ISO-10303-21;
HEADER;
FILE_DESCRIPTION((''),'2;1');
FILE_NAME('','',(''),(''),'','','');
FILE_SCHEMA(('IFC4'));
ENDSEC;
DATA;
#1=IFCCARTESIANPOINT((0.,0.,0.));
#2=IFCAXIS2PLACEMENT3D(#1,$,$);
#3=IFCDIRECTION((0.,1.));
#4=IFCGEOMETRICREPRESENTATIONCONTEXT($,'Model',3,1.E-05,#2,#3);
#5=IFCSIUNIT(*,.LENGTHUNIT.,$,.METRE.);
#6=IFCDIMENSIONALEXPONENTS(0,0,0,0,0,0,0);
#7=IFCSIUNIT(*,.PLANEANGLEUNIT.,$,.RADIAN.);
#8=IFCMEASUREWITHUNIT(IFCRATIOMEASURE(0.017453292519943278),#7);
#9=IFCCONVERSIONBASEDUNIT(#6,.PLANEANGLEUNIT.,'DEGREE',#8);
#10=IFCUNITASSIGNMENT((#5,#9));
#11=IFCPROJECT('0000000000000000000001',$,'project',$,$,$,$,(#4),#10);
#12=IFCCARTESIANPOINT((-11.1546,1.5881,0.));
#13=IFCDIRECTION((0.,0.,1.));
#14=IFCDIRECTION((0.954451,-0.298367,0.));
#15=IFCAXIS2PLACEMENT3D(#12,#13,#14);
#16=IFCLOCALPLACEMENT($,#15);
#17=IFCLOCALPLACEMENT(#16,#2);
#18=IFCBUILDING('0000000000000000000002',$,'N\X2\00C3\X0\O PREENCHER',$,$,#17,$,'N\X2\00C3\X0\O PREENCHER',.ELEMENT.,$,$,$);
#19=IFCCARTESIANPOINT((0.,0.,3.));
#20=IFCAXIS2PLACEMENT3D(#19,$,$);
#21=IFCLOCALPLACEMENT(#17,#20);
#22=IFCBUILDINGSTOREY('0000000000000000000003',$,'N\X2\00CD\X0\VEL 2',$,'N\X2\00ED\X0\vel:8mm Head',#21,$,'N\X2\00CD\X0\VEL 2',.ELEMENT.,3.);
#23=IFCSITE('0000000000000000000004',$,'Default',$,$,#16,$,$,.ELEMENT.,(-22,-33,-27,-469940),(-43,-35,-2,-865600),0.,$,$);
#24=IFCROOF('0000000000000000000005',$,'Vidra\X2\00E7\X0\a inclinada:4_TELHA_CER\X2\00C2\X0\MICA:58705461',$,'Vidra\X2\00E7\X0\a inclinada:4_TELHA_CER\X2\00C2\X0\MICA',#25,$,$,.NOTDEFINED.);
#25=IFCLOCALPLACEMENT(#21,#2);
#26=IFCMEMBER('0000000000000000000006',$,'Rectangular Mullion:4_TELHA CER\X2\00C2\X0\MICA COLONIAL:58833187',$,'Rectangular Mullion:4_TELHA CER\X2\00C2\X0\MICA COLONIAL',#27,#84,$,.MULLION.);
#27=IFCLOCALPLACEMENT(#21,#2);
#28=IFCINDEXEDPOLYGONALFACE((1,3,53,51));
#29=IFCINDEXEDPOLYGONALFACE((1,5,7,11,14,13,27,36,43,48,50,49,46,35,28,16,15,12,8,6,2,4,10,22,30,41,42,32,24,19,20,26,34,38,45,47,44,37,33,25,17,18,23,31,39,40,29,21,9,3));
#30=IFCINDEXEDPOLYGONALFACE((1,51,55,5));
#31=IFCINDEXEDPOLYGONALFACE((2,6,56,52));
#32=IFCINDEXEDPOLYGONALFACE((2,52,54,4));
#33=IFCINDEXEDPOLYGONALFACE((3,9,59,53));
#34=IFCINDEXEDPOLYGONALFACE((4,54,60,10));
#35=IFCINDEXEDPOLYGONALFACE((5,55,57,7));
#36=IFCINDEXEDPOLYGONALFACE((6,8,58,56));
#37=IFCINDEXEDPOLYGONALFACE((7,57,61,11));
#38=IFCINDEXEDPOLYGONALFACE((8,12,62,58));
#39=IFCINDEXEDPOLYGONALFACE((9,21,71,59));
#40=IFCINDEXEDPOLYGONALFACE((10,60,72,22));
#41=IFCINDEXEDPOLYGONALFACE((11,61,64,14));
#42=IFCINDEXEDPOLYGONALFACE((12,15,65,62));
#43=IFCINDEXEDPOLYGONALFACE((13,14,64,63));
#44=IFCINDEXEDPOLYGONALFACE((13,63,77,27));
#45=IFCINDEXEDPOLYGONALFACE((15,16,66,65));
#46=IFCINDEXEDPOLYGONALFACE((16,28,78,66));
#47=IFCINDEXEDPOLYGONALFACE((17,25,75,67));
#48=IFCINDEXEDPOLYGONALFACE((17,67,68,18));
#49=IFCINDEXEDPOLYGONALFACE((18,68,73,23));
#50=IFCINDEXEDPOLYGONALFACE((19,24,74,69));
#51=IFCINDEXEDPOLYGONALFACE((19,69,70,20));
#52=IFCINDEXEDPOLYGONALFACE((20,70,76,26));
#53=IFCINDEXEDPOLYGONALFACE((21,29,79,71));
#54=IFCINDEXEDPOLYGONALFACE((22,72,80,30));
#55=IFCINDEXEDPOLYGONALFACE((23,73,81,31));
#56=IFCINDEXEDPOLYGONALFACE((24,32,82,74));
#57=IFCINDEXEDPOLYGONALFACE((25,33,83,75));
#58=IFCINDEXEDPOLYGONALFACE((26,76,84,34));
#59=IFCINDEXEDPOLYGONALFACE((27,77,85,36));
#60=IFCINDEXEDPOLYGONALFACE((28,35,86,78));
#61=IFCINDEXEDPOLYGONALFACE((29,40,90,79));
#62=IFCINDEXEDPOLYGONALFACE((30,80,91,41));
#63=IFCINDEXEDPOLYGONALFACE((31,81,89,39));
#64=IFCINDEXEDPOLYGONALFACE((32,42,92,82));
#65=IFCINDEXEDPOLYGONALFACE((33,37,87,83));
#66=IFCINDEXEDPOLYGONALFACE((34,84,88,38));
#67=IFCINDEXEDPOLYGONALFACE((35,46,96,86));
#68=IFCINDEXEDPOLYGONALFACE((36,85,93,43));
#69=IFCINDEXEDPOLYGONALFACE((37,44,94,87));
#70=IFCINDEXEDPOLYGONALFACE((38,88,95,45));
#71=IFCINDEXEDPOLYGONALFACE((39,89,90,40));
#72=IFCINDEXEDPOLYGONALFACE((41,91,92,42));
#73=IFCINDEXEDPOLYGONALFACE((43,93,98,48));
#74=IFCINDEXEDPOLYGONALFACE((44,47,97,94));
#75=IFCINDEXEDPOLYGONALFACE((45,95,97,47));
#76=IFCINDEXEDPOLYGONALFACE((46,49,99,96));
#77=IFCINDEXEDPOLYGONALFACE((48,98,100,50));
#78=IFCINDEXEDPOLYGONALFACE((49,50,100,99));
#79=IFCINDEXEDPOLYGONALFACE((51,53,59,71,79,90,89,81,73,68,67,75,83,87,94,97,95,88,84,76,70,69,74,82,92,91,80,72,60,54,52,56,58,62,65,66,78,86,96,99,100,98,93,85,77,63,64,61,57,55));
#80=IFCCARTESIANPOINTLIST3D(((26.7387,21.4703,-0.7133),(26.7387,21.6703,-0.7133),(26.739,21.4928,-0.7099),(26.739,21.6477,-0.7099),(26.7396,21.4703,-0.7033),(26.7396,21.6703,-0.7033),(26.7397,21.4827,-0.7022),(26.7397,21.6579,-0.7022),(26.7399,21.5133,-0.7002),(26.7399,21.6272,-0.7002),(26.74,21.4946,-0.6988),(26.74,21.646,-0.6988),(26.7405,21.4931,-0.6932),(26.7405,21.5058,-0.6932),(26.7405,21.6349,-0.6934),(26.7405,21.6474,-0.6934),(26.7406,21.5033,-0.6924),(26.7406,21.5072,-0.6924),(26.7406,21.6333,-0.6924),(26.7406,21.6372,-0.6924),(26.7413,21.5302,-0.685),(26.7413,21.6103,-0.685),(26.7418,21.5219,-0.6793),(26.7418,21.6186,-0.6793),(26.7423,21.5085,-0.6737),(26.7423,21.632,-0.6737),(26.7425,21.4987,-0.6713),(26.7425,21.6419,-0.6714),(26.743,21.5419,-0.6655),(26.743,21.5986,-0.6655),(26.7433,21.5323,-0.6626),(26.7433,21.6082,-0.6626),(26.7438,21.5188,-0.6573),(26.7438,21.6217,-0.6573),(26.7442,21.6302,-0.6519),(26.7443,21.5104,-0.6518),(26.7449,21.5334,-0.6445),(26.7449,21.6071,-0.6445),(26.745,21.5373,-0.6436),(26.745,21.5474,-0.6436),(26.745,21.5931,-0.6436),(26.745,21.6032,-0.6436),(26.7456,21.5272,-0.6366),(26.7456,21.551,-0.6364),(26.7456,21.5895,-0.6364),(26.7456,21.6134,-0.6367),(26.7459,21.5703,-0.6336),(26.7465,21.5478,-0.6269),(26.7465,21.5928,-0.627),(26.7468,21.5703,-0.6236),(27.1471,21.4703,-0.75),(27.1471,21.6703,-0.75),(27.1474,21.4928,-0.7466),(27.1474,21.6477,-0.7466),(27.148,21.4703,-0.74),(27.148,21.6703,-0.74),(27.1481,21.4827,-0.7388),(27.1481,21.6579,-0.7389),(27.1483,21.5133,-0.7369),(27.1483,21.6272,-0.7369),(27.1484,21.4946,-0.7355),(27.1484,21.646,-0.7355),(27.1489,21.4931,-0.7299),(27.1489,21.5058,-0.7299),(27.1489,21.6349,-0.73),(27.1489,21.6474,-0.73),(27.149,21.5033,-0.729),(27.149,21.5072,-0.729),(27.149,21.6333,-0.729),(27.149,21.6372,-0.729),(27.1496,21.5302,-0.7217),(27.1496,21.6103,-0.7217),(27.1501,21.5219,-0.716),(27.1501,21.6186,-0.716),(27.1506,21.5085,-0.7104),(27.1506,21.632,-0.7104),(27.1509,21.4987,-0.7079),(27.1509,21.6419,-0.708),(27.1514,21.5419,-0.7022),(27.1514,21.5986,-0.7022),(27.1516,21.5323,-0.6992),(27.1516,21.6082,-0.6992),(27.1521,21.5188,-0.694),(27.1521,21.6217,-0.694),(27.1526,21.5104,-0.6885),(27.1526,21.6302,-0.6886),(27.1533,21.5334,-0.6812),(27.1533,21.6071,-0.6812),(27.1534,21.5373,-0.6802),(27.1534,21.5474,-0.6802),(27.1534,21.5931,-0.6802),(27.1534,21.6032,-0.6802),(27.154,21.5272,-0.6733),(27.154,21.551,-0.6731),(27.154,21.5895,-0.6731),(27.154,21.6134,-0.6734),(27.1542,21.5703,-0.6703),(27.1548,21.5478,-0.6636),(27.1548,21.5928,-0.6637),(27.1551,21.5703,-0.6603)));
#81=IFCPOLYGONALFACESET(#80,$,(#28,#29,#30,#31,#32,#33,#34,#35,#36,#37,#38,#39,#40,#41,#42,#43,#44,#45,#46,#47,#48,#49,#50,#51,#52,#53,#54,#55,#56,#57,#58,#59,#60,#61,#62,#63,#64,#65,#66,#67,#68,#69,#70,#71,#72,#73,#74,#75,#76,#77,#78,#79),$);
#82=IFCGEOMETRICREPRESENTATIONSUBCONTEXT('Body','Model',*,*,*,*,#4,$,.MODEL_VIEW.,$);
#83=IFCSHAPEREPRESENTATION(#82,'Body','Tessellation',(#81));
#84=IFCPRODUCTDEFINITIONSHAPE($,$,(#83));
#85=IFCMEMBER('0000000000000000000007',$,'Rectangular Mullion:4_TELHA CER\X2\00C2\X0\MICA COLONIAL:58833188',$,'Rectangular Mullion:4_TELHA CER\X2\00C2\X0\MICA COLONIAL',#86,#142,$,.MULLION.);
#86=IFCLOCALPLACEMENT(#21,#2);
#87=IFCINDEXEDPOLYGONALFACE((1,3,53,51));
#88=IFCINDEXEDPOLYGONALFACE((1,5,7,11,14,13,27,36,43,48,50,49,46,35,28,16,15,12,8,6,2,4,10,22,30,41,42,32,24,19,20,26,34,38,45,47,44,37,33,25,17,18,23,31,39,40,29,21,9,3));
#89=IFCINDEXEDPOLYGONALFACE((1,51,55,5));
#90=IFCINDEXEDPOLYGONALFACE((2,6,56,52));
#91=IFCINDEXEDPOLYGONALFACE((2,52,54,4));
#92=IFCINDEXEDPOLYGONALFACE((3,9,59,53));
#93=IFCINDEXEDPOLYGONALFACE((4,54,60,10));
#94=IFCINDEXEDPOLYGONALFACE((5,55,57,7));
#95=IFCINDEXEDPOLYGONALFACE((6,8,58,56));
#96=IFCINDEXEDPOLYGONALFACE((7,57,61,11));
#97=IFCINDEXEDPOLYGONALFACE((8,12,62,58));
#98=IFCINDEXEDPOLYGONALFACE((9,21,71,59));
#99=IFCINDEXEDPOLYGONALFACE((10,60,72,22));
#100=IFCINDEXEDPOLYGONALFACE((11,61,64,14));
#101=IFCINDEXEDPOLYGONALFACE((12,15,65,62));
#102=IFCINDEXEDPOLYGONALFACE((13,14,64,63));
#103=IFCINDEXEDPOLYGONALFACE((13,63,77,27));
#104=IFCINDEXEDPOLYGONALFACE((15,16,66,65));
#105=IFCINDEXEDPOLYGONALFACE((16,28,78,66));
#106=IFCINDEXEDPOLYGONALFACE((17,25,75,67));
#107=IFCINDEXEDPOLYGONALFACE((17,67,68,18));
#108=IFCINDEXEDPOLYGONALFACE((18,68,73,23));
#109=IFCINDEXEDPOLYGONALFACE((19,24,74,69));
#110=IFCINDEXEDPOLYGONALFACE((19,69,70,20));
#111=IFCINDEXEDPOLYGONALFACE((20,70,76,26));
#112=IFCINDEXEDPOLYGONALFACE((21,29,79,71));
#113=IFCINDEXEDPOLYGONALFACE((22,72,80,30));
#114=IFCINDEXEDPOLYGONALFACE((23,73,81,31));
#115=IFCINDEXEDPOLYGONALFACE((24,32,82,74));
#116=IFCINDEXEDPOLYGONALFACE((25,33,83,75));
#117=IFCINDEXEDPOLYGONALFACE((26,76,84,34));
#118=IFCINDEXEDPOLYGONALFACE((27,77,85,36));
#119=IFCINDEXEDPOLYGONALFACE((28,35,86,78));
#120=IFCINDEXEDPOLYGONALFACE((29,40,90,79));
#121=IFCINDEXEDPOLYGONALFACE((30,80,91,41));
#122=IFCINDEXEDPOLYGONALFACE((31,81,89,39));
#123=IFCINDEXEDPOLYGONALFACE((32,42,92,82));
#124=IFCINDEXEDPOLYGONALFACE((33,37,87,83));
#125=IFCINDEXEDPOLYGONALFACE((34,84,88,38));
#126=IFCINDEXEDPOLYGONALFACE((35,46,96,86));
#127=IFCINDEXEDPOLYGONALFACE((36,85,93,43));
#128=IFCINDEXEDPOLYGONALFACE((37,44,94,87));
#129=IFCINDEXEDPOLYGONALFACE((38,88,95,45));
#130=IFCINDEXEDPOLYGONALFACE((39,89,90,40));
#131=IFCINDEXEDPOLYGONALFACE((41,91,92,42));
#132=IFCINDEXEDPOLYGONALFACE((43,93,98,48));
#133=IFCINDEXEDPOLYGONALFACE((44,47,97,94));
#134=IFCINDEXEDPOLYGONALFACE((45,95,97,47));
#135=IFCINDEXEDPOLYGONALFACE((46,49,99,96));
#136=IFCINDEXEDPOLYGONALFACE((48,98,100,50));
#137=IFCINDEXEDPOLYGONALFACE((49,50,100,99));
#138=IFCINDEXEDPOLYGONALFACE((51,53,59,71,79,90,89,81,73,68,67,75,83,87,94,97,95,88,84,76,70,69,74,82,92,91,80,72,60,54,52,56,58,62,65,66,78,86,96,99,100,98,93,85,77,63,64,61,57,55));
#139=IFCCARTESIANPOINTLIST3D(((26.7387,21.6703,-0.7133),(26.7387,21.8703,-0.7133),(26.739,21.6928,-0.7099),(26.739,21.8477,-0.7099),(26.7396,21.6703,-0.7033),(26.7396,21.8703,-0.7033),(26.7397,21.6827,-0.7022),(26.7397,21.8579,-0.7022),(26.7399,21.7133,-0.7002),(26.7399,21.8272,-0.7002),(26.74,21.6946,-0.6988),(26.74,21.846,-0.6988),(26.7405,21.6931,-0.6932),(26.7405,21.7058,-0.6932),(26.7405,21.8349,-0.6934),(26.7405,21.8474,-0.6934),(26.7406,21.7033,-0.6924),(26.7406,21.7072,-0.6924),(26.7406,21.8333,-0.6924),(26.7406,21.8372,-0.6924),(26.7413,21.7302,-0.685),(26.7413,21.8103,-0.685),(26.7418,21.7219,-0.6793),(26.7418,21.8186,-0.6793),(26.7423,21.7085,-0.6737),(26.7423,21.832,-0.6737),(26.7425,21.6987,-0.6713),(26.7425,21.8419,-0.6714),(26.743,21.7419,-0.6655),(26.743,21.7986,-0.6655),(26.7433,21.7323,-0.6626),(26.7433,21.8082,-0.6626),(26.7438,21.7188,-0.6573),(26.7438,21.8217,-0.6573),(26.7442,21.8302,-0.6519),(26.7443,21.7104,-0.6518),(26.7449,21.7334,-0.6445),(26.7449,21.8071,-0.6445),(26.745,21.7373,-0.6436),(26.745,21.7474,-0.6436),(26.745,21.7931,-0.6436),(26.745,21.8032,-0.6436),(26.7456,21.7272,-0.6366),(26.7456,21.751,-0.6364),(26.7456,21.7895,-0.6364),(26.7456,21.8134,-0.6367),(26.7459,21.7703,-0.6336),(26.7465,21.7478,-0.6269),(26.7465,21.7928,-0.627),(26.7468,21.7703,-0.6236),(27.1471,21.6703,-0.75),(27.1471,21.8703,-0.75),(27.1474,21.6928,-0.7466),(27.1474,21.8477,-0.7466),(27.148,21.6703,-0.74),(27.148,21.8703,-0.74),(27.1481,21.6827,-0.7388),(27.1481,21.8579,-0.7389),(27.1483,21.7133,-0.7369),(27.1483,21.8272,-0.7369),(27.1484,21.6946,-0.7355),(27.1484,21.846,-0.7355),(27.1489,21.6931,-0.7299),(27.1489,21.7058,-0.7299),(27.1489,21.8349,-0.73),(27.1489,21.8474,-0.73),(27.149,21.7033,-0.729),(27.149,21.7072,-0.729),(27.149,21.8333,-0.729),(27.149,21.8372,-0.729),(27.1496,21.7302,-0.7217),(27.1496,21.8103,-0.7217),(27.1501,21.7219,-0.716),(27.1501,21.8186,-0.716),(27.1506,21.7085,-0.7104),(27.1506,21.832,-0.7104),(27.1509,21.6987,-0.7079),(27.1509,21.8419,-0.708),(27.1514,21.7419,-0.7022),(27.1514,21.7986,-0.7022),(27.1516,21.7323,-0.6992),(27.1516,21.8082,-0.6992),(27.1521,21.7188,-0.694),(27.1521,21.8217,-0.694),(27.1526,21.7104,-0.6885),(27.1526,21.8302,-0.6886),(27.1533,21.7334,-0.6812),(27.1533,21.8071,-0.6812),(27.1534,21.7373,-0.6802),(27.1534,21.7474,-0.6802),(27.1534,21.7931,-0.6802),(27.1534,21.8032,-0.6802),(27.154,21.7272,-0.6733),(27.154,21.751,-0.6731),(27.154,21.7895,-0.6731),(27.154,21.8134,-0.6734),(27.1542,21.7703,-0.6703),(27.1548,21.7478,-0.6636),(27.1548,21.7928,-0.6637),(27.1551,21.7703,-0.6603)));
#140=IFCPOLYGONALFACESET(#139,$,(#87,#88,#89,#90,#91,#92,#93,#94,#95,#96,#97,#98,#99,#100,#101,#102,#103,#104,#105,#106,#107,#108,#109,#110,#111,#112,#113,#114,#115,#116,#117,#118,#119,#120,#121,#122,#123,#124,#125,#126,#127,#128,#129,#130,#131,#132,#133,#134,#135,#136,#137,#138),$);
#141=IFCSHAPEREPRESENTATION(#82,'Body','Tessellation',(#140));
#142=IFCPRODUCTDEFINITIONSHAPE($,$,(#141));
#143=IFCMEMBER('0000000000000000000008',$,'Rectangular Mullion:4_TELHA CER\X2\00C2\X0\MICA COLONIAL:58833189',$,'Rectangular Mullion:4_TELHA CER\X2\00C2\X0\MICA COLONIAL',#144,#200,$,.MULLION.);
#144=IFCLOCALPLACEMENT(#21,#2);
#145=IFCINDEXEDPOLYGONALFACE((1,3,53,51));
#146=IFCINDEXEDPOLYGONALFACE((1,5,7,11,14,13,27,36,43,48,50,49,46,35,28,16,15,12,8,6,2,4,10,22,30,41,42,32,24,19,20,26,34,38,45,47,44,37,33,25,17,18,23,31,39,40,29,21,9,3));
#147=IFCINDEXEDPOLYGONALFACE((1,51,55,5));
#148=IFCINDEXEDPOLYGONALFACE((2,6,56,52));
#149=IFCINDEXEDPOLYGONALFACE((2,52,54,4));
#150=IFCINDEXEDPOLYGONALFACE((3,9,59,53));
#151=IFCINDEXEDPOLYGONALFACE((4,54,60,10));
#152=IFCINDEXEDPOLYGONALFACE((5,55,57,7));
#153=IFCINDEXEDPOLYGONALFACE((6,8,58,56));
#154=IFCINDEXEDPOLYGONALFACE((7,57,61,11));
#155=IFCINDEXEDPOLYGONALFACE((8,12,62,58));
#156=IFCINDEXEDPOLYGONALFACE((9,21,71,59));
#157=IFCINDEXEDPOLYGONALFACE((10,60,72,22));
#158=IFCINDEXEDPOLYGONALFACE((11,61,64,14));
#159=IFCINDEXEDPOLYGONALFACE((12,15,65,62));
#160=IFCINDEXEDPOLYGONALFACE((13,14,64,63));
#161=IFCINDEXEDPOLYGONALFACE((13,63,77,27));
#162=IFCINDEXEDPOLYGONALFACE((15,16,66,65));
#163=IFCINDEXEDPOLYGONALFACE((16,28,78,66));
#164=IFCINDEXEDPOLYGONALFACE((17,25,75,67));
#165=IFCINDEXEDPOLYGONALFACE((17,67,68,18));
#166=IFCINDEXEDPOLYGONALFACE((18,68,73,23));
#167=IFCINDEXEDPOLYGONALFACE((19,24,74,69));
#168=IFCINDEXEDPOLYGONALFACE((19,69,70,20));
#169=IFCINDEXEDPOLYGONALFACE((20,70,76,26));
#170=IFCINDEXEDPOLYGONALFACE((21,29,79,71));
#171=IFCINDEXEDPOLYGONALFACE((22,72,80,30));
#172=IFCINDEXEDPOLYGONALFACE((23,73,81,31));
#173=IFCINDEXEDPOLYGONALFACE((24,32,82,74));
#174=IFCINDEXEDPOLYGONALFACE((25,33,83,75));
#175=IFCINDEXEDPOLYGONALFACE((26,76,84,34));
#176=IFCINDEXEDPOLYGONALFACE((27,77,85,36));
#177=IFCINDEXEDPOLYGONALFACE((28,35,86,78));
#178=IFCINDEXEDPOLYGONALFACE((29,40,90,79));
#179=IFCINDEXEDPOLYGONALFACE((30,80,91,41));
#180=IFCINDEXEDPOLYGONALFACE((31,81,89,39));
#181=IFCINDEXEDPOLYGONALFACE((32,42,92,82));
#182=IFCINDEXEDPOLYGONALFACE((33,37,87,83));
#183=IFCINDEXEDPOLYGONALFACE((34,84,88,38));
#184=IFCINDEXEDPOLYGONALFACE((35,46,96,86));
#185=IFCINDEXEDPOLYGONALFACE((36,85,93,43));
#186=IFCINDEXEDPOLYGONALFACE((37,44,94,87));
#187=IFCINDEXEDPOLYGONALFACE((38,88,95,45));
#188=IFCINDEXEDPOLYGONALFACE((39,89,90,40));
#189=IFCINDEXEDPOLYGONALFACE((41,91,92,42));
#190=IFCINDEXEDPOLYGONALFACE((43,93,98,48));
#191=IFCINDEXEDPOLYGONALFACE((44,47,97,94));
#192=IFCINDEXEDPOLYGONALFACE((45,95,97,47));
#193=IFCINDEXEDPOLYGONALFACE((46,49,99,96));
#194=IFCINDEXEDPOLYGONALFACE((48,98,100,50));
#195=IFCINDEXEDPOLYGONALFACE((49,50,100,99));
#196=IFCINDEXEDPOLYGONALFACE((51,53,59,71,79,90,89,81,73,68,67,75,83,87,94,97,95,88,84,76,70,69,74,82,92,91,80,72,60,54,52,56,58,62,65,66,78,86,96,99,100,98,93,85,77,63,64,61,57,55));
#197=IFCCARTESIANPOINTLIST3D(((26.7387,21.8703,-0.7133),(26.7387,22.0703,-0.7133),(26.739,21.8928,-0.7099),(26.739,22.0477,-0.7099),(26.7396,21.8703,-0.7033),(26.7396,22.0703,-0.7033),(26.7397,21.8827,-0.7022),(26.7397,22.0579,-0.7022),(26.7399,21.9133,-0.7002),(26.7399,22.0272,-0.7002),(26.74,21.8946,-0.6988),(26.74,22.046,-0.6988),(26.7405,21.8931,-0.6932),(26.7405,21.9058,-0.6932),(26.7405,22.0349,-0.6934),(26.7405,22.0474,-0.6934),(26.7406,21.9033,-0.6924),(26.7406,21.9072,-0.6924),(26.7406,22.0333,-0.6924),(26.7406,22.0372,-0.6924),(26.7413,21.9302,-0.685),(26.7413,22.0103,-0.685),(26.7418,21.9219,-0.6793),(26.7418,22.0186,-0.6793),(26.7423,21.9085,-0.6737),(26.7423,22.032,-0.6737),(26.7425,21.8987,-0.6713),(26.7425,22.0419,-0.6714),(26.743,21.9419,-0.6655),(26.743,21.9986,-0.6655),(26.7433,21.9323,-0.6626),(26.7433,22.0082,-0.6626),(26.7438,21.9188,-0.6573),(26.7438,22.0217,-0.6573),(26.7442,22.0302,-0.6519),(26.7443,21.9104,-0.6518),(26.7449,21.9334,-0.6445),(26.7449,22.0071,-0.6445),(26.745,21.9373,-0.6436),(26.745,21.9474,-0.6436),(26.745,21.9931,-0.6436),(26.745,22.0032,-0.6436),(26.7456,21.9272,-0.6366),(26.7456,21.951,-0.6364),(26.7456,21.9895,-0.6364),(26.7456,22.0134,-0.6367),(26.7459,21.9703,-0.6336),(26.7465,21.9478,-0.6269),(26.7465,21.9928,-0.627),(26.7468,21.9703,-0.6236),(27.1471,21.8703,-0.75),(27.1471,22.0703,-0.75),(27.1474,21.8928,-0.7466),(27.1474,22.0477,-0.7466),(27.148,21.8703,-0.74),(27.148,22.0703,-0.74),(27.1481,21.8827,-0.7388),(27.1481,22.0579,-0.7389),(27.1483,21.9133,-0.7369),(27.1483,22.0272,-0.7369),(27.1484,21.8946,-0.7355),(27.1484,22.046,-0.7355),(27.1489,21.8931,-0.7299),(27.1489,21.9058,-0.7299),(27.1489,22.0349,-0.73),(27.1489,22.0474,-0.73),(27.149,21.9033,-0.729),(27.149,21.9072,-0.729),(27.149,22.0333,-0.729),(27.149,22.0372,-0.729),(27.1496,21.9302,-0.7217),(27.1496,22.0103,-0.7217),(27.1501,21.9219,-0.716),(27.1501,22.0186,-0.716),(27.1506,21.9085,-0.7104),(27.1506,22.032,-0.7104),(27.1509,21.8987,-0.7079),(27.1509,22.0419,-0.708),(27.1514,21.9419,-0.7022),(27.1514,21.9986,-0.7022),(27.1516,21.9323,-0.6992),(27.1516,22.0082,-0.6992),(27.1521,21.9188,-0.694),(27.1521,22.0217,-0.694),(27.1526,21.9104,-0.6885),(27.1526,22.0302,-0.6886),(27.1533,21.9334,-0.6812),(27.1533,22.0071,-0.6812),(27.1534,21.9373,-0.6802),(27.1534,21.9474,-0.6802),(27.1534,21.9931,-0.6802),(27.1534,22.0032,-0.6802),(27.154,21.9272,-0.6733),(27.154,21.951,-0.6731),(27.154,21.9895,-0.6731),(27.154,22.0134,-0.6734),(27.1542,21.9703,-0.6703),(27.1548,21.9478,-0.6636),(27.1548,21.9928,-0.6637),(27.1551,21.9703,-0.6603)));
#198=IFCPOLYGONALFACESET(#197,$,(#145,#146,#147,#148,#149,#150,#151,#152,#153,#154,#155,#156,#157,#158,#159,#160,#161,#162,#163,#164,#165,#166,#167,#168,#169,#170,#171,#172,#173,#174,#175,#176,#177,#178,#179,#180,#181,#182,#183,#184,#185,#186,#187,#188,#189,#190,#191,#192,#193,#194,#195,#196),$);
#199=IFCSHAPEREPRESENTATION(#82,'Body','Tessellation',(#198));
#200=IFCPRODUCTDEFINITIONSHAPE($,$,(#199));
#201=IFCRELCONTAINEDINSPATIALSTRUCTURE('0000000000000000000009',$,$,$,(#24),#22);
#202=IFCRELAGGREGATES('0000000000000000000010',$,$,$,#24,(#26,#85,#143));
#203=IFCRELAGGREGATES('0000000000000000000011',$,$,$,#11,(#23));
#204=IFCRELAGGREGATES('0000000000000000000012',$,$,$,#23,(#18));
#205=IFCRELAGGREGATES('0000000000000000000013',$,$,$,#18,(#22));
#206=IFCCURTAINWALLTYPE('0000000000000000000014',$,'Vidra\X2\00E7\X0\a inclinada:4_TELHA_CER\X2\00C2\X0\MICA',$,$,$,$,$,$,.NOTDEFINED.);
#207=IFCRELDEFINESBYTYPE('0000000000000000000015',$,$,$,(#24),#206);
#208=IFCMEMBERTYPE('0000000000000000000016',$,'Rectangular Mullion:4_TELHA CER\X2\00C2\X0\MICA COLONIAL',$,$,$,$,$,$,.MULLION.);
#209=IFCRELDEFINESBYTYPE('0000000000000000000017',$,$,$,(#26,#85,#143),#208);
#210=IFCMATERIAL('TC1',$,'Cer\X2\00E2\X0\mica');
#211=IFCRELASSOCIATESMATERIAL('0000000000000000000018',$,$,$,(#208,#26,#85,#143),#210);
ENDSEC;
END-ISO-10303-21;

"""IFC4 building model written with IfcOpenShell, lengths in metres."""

from ifc_helpers import new_model, entity, si_unit, converted_unit, direction, frame, origin, place, context, subcontext, project, spatial, line, arc, indexed_curve, outline, extrude, source, transform, mapped, material, type_object, type_shapes, element, aggregate, save


model = new_model("IFC4")

# Units and contexts
model_context = context("Model", 3, precision=1e-05, world=origin(), true_north=direction((0.0, 1.0)))
body_context = subcontext(model_context, "Body", "Model", "MODEL_VIEW")
ifc_project = project(units=[si_unit("LENGTHUNIT", "METRE"), converted_unit("PLANEANGLEUNIT", "DEGREE", entity("IfcRatioMeasure", 0.017453292519943278), si_unit("PLANEANGLEUNIT", "RADIAN"), dimensions=[0, 0, 0, 0, 0, 0, 0])], contexts=[model_context])

# Site, building, storey
site_placement = place(None, frame((-11.1546, 1.5881, 0.0), z_axis=(0.0, 0.0, 1.0), x_axis=(0.954451, -0.298367, 0.0)))
site = spatial("IfcSite", under=ifc_project, at=site_placement, Name="Default", CompositionType="ELEMENT", RefLatitude=(-22, -33, -27, -469940), RefLongitude=(-43, -35, -2, -865600), RefElevation=0.0)
building_placement = place(site_placement, origin())
building = spatial("IfcBuilding", under=site, at=building_placement, Name="NÃO PREENCHER", LongName="NÃO PREENCHER", CompositionType="ELEMENT")
storey_placement = place(building_placement, frame((0.0, 0.0, 3.0)))
storey = spatial("IfcBuildingStorey", under=building, at=storey_placement, Name="NÍVEL 2", ObjectType="Nível:8mm Head", LongName="NÍVEL 2", CompositionType="ELEMENT", Elevation=3.0)

# Roof, members
curtain_wall_type = type_object("IfcCurtainWallType", Name="Vidraça inclinada:4_TELHA_CERÂMICA", PredefinedType="NOTDEFINED")
roof_placement = place(storey_placement, frame((0.0, 0.0, -3.0)))
roof = element("IfcRoof", 1, at=roof_placement, inside=storey, type_object=curtain_wall_type, Name="Vidraça inclinada:4_TELHA_CERÂMICA:58705461", ObjectType="Vidraça inclinada:4_TELHA_CERÂMICA", PredefinedType="NOTDEFINED")
ifc_material = material(Name="TC1", Category="Cerâmica")
member_type_1 = type_object("IfcMemberType", Name="Rectangular Mullion:4_TELHA CERÂMICA COLONIAL", PredefinedType="MULLION", material=ifc_material)
shared_shape_1 = source(origin(), body_context, "Body", "SweptSolid", [
    extrude(outline(indexed_curve([(-0.029, -0.1), (-0.019, -0.1), (-0.0164, -0.0815), (-0.0089, -0.0645), (-0.0089, -0.0771), (0.061, 0.0), (-0.009, 0.0771), (-0.009, 0.0646), (-0.0165, 0.0816), (-0.019, 0.1), (-0.029, 0.1), (-0.0089, 0.0479), (0.041, 0.0229), (0.041, 0.0329), (0.0131, 0.0425), (-0.008, 0.0631), (-0.008, 0.067), (0.051, 0.0), (-0.008, -0.067), (-0.008, -0.0631), (0.0131, -0.0425), (0.041, -0.0329), (0.041, -0.0229), (-0.0089, -0.0479)], segments=[line(1, 2), arc(2, 3, 4), line(4, 5), arc(5, 6, 7), line(7, 8), arc(8, 9, 10), line(10, 11), arc(11, 12, 13), line(13, 14), arc(14, 15, 16), line(16, 17), arc(17, 18, 19), line(19, 20), arc(20, 21, 22), line(22, 23), arc(23, 24, 1)], self_intersect=False)), frame((0.0, -0.029, -0.41), z_axis=(0.0, 0.0, 1.0), x_axis=(0.0, -1.0, 0.0)), (0.0, 0.0, 1.0), 0.41),
])
type_shapes(member_type_1, [shared_shape_1])
member_1_placement = place(roof_placement, frame((26.7387, 21.5703, 2.2867), z_axis=(-0.99599, 0.0, 0.089469), x_axis=(0.0, 1.0, 0.0)))
member_1 = element("IfcMember", 2, at=member_1_placement, type_object=member_type_1, material=ifc_material, Name="Rectangular Mullion:4_TELHA CERÂMICA COLONIAL:58833187", ObjectType="Rectangular Mullion:4_TELHA CERÂMICA COLONIAL", PredefinedType="MULLION", context=body_context, shape_type="MappedRepresentation", body=[
    mapped(shared_shape_1, transform((0.0, 0.0, 0.0), scale=1.0)),
])
member_2_placement = place(roof_placement, frame((26.7387, 21.7703, 2.2867), z_axis=(-0.99599, 0.0, 0.089469), x_axis=(0.0, 1.0, 0.0)))
member_2 = element("IfcMember", 3, at=member_2_placement, type_object=member_type_1, material=ifc_material, Name="Rectangular Mullion:4_TELHA CERÂMICA COLONIAL:58833188", ObjectType="Rectangular Mullion:4_TELHA CERÂMICA COLONIAL", PredefinedType="MULLION", context=body_context, shape_type="MappedRepresentation", body=[
    mapped(shared_shape_1, transform((0.0, 0.0, 0.0), scale=1.0)),
])
member_3_placement = place(roof_placement, frame((26.7387, 21.9703, 2.2867), z_axis=(-0.99599, 0.0, 0.089469), x_axis=(0.0, 1.0, 0.0)))
member_3 = element("IfcMember", 4, at=member_3_placement, type_object=member_type_1, material=ifc_material, Name="Rectangular Mullion:4_TELHA CERÂMICA COLONIAL:58833189", ObjectType="Rectangular Mullion:4_TELHA CERÂMICA COLONIAL", PredefinedType="MULLION", context=body_context, shape_type="MappedRepresentation", body=[
    mapped(shared_shape_1, transform((0.0, 0.0, 0.0), scale=1.0)),
])
aggregate(roof, [member_1, member_2, member_3])

save(model, "model.ifc")
